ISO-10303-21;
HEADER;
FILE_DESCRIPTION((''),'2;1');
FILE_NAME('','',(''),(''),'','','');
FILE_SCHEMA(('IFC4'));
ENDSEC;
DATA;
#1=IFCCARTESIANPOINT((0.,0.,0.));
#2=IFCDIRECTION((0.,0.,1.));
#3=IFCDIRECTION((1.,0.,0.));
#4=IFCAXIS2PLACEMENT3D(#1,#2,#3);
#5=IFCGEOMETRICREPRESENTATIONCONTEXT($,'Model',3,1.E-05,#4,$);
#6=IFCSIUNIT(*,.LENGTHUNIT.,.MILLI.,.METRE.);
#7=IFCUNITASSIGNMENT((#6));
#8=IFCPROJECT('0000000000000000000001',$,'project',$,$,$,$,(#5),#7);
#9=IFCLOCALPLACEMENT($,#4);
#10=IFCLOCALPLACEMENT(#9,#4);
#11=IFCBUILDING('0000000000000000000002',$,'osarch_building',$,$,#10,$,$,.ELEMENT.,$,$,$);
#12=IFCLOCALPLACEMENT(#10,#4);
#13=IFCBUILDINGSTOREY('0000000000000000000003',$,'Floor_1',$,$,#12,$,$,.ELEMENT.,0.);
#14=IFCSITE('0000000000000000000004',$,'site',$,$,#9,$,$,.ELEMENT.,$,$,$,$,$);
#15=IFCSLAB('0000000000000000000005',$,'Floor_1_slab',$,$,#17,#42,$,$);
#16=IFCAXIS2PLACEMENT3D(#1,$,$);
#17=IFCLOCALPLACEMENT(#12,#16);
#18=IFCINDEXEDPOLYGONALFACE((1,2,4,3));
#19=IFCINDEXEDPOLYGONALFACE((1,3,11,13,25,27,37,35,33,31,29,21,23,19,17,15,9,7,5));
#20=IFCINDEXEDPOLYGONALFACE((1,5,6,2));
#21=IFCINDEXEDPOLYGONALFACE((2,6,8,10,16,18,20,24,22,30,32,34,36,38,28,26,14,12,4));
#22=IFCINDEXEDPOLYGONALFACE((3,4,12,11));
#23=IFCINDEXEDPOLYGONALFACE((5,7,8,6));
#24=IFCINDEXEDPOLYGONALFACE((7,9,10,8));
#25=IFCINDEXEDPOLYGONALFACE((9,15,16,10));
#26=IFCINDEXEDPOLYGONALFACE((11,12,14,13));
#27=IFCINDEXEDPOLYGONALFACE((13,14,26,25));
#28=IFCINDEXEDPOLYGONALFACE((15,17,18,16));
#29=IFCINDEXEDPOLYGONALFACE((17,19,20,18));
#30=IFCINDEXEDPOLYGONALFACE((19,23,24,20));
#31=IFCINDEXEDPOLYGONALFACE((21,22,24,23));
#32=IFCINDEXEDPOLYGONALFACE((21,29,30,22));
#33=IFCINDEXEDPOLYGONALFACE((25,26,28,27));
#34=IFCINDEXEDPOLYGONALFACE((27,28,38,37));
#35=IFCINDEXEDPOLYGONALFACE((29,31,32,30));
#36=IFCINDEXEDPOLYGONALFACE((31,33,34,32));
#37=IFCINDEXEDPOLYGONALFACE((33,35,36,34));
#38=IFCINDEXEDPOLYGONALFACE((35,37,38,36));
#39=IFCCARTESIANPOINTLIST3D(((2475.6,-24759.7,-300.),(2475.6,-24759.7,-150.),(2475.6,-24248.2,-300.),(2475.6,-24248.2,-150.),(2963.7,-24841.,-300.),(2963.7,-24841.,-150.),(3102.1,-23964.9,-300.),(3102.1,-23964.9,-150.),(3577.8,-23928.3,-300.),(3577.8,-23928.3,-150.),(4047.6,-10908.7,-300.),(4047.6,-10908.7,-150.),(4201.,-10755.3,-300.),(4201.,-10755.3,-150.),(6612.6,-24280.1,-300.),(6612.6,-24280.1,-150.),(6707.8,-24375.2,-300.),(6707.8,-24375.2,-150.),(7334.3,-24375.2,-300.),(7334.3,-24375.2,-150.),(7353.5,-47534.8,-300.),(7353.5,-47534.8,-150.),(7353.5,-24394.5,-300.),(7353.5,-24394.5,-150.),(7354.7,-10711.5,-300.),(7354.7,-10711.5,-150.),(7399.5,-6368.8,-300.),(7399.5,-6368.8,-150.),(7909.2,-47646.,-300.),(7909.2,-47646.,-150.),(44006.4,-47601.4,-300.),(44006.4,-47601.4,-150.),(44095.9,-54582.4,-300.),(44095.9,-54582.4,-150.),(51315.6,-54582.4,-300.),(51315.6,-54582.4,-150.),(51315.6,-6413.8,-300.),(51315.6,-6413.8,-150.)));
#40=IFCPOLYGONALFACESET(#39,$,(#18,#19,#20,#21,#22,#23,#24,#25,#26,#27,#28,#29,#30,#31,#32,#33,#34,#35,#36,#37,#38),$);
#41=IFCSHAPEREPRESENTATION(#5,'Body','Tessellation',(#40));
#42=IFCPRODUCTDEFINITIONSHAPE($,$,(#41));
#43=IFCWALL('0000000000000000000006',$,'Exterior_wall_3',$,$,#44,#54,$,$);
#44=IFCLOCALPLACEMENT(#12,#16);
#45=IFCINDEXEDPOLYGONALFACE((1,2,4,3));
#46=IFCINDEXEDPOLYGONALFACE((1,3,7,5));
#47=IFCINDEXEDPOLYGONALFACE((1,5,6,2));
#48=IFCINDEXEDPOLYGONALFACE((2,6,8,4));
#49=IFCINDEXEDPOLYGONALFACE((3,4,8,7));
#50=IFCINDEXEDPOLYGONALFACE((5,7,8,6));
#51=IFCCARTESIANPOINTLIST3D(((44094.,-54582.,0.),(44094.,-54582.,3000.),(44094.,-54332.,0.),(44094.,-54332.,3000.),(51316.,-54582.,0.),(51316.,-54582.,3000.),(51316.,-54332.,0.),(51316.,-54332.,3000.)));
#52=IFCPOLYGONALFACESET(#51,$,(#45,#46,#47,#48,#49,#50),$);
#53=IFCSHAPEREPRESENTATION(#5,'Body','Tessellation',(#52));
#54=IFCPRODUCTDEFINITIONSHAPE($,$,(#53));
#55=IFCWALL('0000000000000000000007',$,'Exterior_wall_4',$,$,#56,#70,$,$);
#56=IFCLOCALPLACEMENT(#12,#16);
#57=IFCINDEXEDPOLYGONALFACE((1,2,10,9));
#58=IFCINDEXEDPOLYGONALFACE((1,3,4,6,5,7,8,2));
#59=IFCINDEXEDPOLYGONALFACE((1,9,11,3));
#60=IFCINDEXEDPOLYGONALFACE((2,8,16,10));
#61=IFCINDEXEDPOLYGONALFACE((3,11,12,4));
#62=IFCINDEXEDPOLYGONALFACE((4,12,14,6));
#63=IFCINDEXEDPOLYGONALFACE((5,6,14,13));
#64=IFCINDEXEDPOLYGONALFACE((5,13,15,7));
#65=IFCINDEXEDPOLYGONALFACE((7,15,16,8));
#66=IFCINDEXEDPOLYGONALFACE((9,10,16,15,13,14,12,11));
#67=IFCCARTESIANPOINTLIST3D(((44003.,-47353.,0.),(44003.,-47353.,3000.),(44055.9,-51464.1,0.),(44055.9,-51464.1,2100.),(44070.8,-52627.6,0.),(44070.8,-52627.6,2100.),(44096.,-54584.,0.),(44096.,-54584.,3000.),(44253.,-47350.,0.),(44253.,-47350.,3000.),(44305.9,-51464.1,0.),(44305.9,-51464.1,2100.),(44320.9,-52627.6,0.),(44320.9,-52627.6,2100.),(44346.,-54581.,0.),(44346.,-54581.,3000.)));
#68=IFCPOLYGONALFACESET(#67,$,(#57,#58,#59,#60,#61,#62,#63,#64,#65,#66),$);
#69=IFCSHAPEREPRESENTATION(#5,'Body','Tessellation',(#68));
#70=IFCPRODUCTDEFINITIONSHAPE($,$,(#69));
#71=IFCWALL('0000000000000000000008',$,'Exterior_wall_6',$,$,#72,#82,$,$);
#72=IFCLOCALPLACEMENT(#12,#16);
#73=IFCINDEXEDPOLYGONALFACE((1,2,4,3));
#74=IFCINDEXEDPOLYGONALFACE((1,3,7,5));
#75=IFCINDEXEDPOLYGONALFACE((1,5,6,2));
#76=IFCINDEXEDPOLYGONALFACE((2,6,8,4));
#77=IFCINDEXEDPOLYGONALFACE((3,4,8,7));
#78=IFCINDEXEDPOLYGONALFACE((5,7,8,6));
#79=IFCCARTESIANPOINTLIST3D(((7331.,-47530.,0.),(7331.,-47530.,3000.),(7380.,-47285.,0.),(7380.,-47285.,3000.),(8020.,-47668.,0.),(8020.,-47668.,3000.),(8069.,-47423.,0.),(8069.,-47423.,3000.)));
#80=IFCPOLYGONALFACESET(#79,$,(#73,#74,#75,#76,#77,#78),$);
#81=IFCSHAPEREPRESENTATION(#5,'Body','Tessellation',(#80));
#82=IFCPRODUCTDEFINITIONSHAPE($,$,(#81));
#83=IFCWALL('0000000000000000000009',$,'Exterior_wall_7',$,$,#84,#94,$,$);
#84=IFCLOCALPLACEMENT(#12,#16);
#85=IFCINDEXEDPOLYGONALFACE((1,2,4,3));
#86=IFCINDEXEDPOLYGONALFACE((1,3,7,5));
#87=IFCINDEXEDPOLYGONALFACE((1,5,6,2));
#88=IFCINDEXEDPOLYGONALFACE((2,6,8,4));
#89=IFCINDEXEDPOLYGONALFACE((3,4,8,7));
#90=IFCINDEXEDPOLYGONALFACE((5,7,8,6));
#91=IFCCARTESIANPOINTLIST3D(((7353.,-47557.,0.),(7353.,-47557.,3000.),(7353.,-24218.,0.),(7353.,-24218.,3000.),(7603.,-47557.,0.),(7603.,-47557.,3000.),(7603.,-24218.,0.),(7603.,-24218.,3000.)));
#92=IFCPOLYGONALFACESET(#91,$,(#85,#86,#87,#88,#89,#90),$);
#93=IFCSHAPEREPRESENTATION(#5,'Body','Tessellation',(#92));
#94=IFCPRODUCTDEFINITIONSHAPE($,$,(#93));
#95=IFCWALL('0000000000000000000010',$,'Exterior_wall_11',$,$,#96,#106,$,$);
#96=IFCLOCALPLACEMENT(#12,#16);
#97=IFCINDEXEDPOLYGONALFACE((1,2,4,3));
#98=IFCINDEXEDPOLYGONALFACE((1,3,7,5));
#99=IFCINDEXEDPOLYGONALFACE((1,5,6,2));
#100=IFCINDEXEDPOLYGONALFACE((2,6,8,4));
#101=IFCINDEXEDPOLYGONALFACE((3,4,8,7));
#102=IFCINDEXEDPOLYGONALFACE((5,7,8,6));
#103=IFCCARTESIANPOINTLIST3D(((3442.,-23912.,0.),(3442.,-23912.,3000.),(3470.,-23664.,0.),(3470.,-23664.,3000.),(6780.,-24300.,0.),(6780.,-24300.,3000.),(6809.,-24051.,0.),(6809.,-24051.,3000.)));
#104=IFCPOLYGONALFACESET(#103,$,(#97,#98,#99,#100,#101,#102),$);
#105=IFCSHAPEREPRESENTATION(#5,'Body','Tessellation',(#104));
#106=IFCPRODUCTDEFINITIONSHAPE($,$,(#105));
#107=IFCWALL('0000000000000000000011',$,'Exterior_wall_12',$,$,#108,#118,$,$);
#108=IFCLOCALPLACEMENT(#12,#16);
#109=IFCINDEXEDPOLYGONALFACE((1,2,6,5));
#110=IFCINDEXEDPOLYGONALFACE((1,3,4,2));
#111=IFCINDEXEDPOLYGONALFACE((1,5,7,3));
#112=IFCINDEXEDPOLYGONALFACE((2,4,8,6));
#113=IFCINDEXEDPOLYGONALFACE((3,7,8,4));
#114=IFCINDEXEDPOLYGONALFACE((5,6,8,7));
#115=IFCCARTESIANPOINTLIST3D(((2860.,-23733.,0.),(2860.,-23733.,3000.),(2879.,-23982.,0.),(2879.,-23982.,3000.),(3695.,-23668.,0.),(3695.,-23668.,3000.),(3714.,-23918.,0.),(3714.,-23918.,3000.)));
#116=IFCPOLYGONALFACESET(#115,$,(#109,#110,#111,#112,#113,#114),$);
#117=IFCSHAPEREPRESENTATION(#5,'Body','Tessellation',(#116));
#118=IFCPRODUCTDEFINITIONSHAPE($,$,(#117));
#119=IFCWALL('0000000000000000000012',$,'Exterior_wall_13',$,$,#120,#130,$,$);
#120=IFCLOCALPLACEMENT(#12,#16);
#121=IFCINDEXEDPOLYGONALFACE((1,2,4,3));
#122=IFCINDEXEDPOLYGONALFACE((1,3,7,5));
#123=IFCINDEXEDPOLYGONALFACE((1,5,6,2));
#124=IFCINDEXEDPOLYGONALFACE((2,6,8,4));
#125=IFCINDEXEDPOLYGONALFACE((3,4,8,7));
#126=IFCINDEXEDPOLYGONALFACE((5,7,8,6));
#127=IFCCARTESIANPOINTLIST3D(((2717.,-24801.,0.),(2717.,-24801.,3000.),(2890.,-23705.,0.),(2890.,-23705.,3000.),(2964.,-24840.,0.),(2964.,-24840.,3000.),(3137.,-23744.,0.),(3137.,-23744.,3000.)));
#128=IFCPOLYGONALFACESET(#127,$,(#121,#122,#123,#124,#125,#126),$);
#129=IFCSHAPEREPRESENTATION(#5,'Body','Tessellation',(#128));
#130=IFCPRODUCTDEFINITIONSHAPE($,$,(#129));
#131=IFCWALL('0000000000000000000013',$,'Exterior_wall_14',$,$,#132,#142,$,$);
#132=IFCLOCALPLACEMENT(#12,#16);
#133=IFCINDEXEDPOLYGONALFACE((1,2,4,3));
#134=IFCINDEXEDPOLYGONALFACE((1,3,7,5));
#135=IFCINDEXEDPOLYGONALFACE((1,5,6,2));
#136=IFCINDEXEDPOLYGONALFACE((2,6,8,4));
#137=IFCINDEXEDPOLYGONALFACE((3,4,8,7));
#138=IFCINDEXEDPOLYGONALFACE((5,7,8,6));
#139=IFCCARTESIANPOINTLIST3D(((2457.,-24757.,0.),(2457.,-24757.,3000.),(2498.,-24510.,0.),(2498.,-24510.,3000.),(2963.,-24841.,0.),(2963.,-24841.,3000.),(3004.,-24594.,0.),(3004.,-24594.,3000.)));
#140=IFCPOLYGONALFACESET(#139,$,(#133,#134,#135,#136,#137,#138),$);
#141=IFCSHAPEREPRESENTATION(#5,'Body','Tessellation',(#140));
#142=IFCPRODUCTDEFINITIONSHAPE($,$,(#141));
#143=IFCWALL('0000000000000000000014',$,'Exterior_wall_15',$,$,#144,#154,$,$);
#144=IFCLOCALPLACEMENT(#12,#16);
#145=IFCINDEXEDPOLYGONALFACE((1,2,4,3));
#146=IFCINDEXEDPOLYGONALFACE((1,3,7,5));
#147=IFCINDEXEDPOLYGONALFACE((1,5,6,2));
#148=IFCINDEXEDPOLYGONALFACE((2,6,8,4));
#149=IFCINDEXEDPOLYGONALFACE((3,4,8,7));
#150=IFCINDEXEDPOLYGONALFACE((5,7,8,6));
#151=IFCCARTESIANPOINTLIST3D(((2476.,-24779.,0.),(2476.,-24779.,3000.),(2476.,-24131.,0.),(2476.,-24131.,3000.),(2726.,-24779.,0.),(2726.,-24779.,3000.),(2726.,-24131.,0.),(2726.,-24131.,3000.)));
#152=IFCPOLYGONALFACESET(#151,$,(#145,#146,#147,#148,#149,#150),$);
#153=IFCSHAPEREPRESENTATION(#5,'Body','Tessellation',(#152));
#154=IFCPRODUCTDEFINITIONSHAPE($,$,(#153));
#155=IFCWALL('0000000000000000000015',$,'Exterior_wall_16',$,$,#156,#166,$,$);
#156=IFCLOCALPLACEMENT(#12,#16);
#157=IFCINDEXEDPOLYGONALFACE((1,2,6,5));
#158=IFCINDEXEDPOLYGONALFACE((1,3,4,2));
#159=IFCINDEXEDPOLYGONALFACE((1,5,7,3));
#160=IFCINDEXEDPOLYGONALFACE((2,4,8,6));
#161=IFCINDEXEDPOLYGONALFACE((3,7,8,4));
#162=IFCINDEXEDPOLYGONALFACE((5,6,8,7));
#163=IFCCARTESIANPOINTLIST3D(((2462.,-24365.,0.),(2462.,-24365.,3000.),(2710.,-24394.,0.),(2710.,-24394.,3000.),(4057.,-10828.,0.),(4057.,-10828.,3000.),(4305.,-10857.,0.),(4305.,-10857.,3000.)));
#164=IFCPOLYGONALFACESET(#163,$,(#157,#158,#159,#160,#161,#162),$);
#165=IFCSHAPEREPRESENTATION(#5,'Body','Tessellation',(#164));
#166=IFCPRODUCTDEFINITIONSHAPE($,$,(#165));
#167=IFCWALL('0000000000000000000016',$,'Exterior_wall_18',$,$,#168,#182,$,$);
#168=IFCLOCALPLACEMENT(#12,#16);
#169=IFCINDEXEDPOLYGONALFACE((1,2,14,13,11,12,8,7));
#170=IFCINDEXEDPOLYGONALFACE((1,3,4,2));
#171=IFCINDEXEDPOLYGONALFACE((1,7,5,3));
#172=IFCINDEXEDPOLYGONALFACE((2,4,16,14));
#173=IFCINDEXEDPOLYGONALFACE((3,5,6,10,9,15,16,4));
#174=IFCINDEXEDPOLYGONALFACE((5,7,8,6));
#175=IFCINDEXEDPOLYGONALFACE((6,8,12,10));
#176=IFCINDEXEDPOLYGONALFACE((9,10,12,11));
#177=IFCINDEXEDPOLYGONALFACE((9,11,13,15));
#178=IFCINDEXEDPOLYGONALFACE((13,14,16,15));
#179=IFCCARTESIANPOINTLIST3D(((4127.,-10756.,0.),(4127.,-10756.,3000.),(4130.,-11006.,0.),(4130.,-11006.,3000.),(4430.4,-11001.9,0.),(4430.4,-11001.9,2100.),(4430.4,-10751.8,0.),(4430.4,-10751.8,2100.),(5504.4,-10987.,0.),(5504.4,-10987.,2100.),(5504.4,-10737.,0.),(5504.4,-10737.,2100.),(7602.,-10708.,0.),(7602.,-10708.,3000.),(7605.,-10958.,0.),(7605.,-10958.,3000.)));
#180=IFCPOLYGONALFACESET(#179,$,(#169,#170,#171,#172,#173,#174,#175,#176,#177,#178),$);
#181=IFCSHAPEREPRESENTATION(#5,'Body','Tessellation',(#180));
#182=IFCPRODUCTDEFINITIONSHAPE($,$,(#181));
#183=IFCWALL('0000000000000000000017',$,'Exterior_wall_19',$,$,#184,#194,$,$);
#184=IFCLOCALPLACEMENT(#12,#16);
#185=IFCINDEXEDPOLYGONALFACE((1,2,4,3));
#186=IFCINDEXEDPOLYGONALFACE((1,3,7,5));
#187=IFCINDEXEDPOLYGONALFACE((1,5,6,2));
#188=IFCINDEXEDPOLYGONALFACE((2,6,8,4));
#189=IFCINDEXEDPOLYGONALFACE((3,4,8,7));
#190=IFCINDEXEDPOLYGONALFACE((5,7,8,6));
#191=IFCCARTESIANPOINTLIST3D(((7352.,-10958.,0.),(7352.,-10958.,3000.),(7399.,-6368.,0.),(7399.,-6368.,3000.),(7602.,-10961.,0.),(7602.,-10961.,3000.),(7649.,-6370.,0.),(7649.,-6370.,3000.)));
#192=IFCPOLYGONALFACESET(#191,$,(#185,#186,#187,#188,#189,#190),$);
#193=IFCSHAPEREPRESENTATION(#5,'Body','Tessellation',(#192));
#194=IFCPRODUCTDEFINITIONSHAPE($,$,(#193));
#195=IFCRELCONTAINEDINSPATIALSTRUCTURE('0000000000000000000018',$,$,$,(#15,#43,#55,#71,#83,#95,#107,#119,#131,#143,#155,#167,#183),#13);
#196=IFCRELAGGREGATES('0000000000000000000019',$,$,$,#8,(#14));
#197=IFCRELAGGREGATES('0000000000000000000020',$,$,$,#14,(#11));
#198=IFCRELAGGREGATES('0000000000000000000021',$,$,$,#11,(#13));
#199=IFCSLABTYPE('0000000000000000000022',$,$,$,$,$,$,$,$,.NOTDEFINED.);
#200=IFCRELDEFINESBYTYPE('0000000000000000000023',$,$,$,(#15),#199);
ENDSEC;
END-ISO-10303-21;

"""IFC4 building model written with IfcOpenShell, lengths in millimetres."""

from ifc_helpers import new_model, si_unit, frame, origin_with_axes, place, context, project, spatial, polyline, outline, extrude, source, transform, mapped, type_object, type_shapes, element, save


model = new_model("IFC4")

# Units and contexts
model_context = context("Model", 3, precision=1e-05, world=origin_with_axes())
ifc_project = project(units=[si_unit("LENGTHUNIT", "METRE", prefix="MILLI")], contexts=[model_context])

# Site, building, storey
site_placement = place(None, origin_with_axes())
site = spatial("IfcSite", under=ifc_project, at=site_placement, Name="site", CompositionType="ELEMENT")
building_placement = place(site_placement, origin_with_axes())
building = spatial("IfcBuilding", under=site, at=building_placement, Name="osarch_building", CompositionType="ELEMENT")
storey_placement = place(building_placement, origin_with_axes())
storey = spatial("IfcBuildingStorey", under=building, at=storey_placement, Name="Floor_1", CompositionType="ELEMENT", Elevation=0.0)

# Slab
slab_type = type_object("IfcSlabType", PredefinedType="NOTDEFINED")
shared_shape = source(origin_with_axes(), model_context, "Body", "SweptSolid", [
    extrude(outline(polyline([(7399.5, -6368.8, -150.0), (51315.6, -6413.8, -150.0), (51315.6, -54582.4, -150.0), (44095.9, -54582.4, -150.0), (44006.4, -47601.4, -150.0), (7909.2, -47646.0, -150.0), (7353.5, -47534.8, -150.0), (7353.5, -24394.5, -150.0), (7334.3, -24375.2, -150.0), (6707.8, -24375.2, -150.0), (6612.6, -24280.1, -150.0), (3577.8, -23928.3, -150.0), (3102.1, -23964.9, -150.0), (2963.7, -24841.0, -150.0), (2475.6, -24759.7, -150.0), (2475.6, -24248.2, -150.0), (4047.6, -10908.7, -150.0), (4201.0, -10755.3, -150.0), (7354.7, -10711.5, -150.0), (7399.5, -6368.8, -150.0)])), frame((0.0, 0.0, -150.0), z_axis=(0.0, 0.0, 1.0), x_axis=(1.0, 0.0, 0.0)), (0.0, 0.0, 1.0), 150.0),
])
type_shapes(slab_type, [shared_shape])
element("IfcSlab", 1, inside=storey, type_object=slab_type, Name="Floor_1_slab", context=model_context, shape_type="MappedRepresentation", body=[
    mapped(shared_shape, transform((0.0, 0.0, 0.0), x_axis=(1.0, 0.0, 0.0), y_axis=(0.0, 1.0, 0.0), z_axis=(0.0, 0.0, 1.0), scale=1.0)),
])

# Wall
element("IfcWall", 2, inside=storey, Name="Exterior_wall_3", context=model_context, shape_type="SweptSolid", body=[
    extrude(outline(polyline([(51316.0, -54332.0, 0.0), (51316.0, -54582.0, 0.0), (44094.0, -54582.0, 0.0), (44094.0, -54332.0, 0.0), (51316.0, -54332.0, 0.0)])), origin_with_axes(), (0.0, 0.0, 1.0), 3000.0),
])

# Wall, opening
wall_1 = element("IfcWall", 3, inside=storey, Name="Exterior_wall_4", context=model_context, shape_type="SweptSolid", body=[
    extrude(outline(polyline([(44346.0, -54581.0, 0.0), (44096.0, -54584.0, 0.0), (44003.0, -47353.0, 0.0), (44253.0, -47350.0, 0.0), (44346.0, -54581.0, 0.0)])), origin_with_axes(), (0.0, 0.0, 1.0), 3000.0),
])
element("IfcOpeningElement", 4, inside=storey, cuts=wall_1, context=model_context, shape_type="SweptSolid", body=[
    extrude(outline(polyline([(42782.3, -51464.1, 0.0), (42782.3, -52627.6, 0.0), (45691.2, -52627.6, 0.0), (45691.2, -51464.1, 0.0), (42782.3, -51464.1, 0.0)])), origin_with_axes(), (0.0, 0.0, 1.0), 2100.0),
])

# Walls
element("IfcWall", 5, inside=storey, Name="Exterior_wall_6", context=model_context, shape_type="SweptSolid", body=[
    extrude(outline(polyline([(8069.0, -47423.0, 0.0), (8020.0, -47668.0, 0.0), (7331.0, -47530.0, 0.0), (7380.0, -47285.0, 0.0), (8069.0, -47423.0, 0.0)])), origin_with_axes(), (0.0, 0.0, 1.0), 3000.0),
])
element("IfcWall", 6, inside=storey, Name="Exterior_wall_7", context=model_context, shape_type="SweptSolid", body=[
    extrude(outline(polyline([(7603.0, -47557.0, 0.0), (7353.0, -47557.0, 0.0), (7353.0, -24218.0, 0.0), (7603.0, -24218.0, 0.0), (7603.0, -47557.0, 0.0)])), origin_with_axes(), (0.0, 0.0, 1.0), 3000.0),
])

# Walls
element("IfcWall", 7, inside=storey, Name="Exterior_wall_11", context=model_context, shape_type="SweptSolid", body=[
    extrude(outline(polyline([(6809.0, -24051.0, 0.0), (6780.0, -24300.0, 0.0), (3442.0, -23912.0, 0.0), (3470.0, -23664.0, 0.0), (6809.0, -24051.0, 0.0)])), origin_with_axes(), (0.0, 0.0, 1.0), 3000.0),
])
element("IfcWall", 8, inside=storey, Name="Exterior_wall_12", context=model_context, shape_type="SweptSolid", body=[
    extrude(outline(polyline([(3695.0, -23668.0, 0.0), (3714.0, -23918.0, 0.0), (2879.0, -23982.0, 0.0), (2860.0, -23733.0, 0.0), (3695.0, -23668.0, 0.0)])), origin_with_axes(), (0.0, 0.0, 1.0), 3000.0),
])
element("IfcWall", 9, inside=storey, Name="Exterior_wall_13", context=model_context, shape_type="SweptSolid", body=[
    extrude(outline(polyline([(2890.0, -23705.0, 0.0), (3137.0, -23744.0, 0.0), (2964.0, -24840.0, 0.0), (2717.0, -24801.0, 0.0), (2890.0, -23705.0, 0.0)])), origin_with_axes(), (0.0, 0.0, 1.0), 3000.0),
])
element("IfcWall", 10, inside=storey, Name="Exterior_wall_14", context=model_context, shape_type="SweptSolid", body=[
    extrude(outline(polyline([(3004.0, -24594.0, 0.0), (2963.0, -24841.0, 0.0), (2457.0, -24757.0, 0.0), (2498.0, -24510.0, 0.0), (3004.0, -24594.0, 0.0)])), origin_with_axes(), (0.0, 0.0, 1.0), 3000.0),
])
element("IfcWall", 11, inside=storey, Name="Exterior_wall_15", context=model_context, shape_type="SweptSolid", body=[
    extrude(outline(polyline([(2726.0, -24779.0, 0.0), (2476.0, -24779.0, 0.0), (2476.0, -24131.0, 0.0), (2726.0, -24131.0, 0.0), (2726.0, -24779.0, 0.0)])), origin_with_axes(), (0.0, 0.0, 1.0), 3000.0),
])
element("IfcWall", 12, inside=storey, Name="Exterior_wall_16", context=model_context, shape_type="SweptSolid", body=[
    extrude(outline(polyline([(2710.0, -24394.0, 0.0), (2462.0, -24365.0, 0.0), (4057.0, -10828.0, 0.0), (4305.0, -10857.0, 0.0), (2710.0, -24394.0, 0.0)])), origin_with_axes(), (0.0, 0.0, 1.0), 3000.0),
])

# Wall, opening
wall_2 = element("IfcWall", 13, inside=storey, Name="Exterior_wall_18", context=model_context, shape_type="SweptSolid", body=[
    extrude(outline(polyline([(4130.0, -11006.0, 0.0), (4127.0, -10756.0, 0.0), (7602.0, -10708.0, 0.0), (7605.0, -10958.0, 0.0), (4130.0, -11006.0, 0.0)])), origin_with_axes(), (0.0, 0.0, 1.0), 3000.0),
])
element("IfcOpeningElement", 14, inside=storey, cuts=wall_2, context=model_context, shape_type="SweptSolid", body=[
    extrude(outline(polyline([(4430.4, -9934.8, 0.0), (4430.4, -11456.4, 0.0), (5504.4, -11456.4, 0.0), (5504.4, -9934.8, 0.0), (4430.4, -9934.8, 0.0)])), origin_with_axes(), (0.0, 0.0, 1.0), 2100.0),
])

# Wall
element("IfcWall", 15, inside=storey, Name="Exterior_wall_19", context=model_context, shape_type="SweptSolid", body=[
    extrude(outline(polyline([(7602.0, -10961.0, 0.0), (7352.0, -10958.0, 0.0), (7399.0, -6368.0, 0.0), (7649.0, -6370.0, 0.0), (7602.0, -10961.0, 0.0)])), origin_with_axes(), (0.0, 0.0, 1.0), 3000.0),
])

save(model, "model.ifc")
